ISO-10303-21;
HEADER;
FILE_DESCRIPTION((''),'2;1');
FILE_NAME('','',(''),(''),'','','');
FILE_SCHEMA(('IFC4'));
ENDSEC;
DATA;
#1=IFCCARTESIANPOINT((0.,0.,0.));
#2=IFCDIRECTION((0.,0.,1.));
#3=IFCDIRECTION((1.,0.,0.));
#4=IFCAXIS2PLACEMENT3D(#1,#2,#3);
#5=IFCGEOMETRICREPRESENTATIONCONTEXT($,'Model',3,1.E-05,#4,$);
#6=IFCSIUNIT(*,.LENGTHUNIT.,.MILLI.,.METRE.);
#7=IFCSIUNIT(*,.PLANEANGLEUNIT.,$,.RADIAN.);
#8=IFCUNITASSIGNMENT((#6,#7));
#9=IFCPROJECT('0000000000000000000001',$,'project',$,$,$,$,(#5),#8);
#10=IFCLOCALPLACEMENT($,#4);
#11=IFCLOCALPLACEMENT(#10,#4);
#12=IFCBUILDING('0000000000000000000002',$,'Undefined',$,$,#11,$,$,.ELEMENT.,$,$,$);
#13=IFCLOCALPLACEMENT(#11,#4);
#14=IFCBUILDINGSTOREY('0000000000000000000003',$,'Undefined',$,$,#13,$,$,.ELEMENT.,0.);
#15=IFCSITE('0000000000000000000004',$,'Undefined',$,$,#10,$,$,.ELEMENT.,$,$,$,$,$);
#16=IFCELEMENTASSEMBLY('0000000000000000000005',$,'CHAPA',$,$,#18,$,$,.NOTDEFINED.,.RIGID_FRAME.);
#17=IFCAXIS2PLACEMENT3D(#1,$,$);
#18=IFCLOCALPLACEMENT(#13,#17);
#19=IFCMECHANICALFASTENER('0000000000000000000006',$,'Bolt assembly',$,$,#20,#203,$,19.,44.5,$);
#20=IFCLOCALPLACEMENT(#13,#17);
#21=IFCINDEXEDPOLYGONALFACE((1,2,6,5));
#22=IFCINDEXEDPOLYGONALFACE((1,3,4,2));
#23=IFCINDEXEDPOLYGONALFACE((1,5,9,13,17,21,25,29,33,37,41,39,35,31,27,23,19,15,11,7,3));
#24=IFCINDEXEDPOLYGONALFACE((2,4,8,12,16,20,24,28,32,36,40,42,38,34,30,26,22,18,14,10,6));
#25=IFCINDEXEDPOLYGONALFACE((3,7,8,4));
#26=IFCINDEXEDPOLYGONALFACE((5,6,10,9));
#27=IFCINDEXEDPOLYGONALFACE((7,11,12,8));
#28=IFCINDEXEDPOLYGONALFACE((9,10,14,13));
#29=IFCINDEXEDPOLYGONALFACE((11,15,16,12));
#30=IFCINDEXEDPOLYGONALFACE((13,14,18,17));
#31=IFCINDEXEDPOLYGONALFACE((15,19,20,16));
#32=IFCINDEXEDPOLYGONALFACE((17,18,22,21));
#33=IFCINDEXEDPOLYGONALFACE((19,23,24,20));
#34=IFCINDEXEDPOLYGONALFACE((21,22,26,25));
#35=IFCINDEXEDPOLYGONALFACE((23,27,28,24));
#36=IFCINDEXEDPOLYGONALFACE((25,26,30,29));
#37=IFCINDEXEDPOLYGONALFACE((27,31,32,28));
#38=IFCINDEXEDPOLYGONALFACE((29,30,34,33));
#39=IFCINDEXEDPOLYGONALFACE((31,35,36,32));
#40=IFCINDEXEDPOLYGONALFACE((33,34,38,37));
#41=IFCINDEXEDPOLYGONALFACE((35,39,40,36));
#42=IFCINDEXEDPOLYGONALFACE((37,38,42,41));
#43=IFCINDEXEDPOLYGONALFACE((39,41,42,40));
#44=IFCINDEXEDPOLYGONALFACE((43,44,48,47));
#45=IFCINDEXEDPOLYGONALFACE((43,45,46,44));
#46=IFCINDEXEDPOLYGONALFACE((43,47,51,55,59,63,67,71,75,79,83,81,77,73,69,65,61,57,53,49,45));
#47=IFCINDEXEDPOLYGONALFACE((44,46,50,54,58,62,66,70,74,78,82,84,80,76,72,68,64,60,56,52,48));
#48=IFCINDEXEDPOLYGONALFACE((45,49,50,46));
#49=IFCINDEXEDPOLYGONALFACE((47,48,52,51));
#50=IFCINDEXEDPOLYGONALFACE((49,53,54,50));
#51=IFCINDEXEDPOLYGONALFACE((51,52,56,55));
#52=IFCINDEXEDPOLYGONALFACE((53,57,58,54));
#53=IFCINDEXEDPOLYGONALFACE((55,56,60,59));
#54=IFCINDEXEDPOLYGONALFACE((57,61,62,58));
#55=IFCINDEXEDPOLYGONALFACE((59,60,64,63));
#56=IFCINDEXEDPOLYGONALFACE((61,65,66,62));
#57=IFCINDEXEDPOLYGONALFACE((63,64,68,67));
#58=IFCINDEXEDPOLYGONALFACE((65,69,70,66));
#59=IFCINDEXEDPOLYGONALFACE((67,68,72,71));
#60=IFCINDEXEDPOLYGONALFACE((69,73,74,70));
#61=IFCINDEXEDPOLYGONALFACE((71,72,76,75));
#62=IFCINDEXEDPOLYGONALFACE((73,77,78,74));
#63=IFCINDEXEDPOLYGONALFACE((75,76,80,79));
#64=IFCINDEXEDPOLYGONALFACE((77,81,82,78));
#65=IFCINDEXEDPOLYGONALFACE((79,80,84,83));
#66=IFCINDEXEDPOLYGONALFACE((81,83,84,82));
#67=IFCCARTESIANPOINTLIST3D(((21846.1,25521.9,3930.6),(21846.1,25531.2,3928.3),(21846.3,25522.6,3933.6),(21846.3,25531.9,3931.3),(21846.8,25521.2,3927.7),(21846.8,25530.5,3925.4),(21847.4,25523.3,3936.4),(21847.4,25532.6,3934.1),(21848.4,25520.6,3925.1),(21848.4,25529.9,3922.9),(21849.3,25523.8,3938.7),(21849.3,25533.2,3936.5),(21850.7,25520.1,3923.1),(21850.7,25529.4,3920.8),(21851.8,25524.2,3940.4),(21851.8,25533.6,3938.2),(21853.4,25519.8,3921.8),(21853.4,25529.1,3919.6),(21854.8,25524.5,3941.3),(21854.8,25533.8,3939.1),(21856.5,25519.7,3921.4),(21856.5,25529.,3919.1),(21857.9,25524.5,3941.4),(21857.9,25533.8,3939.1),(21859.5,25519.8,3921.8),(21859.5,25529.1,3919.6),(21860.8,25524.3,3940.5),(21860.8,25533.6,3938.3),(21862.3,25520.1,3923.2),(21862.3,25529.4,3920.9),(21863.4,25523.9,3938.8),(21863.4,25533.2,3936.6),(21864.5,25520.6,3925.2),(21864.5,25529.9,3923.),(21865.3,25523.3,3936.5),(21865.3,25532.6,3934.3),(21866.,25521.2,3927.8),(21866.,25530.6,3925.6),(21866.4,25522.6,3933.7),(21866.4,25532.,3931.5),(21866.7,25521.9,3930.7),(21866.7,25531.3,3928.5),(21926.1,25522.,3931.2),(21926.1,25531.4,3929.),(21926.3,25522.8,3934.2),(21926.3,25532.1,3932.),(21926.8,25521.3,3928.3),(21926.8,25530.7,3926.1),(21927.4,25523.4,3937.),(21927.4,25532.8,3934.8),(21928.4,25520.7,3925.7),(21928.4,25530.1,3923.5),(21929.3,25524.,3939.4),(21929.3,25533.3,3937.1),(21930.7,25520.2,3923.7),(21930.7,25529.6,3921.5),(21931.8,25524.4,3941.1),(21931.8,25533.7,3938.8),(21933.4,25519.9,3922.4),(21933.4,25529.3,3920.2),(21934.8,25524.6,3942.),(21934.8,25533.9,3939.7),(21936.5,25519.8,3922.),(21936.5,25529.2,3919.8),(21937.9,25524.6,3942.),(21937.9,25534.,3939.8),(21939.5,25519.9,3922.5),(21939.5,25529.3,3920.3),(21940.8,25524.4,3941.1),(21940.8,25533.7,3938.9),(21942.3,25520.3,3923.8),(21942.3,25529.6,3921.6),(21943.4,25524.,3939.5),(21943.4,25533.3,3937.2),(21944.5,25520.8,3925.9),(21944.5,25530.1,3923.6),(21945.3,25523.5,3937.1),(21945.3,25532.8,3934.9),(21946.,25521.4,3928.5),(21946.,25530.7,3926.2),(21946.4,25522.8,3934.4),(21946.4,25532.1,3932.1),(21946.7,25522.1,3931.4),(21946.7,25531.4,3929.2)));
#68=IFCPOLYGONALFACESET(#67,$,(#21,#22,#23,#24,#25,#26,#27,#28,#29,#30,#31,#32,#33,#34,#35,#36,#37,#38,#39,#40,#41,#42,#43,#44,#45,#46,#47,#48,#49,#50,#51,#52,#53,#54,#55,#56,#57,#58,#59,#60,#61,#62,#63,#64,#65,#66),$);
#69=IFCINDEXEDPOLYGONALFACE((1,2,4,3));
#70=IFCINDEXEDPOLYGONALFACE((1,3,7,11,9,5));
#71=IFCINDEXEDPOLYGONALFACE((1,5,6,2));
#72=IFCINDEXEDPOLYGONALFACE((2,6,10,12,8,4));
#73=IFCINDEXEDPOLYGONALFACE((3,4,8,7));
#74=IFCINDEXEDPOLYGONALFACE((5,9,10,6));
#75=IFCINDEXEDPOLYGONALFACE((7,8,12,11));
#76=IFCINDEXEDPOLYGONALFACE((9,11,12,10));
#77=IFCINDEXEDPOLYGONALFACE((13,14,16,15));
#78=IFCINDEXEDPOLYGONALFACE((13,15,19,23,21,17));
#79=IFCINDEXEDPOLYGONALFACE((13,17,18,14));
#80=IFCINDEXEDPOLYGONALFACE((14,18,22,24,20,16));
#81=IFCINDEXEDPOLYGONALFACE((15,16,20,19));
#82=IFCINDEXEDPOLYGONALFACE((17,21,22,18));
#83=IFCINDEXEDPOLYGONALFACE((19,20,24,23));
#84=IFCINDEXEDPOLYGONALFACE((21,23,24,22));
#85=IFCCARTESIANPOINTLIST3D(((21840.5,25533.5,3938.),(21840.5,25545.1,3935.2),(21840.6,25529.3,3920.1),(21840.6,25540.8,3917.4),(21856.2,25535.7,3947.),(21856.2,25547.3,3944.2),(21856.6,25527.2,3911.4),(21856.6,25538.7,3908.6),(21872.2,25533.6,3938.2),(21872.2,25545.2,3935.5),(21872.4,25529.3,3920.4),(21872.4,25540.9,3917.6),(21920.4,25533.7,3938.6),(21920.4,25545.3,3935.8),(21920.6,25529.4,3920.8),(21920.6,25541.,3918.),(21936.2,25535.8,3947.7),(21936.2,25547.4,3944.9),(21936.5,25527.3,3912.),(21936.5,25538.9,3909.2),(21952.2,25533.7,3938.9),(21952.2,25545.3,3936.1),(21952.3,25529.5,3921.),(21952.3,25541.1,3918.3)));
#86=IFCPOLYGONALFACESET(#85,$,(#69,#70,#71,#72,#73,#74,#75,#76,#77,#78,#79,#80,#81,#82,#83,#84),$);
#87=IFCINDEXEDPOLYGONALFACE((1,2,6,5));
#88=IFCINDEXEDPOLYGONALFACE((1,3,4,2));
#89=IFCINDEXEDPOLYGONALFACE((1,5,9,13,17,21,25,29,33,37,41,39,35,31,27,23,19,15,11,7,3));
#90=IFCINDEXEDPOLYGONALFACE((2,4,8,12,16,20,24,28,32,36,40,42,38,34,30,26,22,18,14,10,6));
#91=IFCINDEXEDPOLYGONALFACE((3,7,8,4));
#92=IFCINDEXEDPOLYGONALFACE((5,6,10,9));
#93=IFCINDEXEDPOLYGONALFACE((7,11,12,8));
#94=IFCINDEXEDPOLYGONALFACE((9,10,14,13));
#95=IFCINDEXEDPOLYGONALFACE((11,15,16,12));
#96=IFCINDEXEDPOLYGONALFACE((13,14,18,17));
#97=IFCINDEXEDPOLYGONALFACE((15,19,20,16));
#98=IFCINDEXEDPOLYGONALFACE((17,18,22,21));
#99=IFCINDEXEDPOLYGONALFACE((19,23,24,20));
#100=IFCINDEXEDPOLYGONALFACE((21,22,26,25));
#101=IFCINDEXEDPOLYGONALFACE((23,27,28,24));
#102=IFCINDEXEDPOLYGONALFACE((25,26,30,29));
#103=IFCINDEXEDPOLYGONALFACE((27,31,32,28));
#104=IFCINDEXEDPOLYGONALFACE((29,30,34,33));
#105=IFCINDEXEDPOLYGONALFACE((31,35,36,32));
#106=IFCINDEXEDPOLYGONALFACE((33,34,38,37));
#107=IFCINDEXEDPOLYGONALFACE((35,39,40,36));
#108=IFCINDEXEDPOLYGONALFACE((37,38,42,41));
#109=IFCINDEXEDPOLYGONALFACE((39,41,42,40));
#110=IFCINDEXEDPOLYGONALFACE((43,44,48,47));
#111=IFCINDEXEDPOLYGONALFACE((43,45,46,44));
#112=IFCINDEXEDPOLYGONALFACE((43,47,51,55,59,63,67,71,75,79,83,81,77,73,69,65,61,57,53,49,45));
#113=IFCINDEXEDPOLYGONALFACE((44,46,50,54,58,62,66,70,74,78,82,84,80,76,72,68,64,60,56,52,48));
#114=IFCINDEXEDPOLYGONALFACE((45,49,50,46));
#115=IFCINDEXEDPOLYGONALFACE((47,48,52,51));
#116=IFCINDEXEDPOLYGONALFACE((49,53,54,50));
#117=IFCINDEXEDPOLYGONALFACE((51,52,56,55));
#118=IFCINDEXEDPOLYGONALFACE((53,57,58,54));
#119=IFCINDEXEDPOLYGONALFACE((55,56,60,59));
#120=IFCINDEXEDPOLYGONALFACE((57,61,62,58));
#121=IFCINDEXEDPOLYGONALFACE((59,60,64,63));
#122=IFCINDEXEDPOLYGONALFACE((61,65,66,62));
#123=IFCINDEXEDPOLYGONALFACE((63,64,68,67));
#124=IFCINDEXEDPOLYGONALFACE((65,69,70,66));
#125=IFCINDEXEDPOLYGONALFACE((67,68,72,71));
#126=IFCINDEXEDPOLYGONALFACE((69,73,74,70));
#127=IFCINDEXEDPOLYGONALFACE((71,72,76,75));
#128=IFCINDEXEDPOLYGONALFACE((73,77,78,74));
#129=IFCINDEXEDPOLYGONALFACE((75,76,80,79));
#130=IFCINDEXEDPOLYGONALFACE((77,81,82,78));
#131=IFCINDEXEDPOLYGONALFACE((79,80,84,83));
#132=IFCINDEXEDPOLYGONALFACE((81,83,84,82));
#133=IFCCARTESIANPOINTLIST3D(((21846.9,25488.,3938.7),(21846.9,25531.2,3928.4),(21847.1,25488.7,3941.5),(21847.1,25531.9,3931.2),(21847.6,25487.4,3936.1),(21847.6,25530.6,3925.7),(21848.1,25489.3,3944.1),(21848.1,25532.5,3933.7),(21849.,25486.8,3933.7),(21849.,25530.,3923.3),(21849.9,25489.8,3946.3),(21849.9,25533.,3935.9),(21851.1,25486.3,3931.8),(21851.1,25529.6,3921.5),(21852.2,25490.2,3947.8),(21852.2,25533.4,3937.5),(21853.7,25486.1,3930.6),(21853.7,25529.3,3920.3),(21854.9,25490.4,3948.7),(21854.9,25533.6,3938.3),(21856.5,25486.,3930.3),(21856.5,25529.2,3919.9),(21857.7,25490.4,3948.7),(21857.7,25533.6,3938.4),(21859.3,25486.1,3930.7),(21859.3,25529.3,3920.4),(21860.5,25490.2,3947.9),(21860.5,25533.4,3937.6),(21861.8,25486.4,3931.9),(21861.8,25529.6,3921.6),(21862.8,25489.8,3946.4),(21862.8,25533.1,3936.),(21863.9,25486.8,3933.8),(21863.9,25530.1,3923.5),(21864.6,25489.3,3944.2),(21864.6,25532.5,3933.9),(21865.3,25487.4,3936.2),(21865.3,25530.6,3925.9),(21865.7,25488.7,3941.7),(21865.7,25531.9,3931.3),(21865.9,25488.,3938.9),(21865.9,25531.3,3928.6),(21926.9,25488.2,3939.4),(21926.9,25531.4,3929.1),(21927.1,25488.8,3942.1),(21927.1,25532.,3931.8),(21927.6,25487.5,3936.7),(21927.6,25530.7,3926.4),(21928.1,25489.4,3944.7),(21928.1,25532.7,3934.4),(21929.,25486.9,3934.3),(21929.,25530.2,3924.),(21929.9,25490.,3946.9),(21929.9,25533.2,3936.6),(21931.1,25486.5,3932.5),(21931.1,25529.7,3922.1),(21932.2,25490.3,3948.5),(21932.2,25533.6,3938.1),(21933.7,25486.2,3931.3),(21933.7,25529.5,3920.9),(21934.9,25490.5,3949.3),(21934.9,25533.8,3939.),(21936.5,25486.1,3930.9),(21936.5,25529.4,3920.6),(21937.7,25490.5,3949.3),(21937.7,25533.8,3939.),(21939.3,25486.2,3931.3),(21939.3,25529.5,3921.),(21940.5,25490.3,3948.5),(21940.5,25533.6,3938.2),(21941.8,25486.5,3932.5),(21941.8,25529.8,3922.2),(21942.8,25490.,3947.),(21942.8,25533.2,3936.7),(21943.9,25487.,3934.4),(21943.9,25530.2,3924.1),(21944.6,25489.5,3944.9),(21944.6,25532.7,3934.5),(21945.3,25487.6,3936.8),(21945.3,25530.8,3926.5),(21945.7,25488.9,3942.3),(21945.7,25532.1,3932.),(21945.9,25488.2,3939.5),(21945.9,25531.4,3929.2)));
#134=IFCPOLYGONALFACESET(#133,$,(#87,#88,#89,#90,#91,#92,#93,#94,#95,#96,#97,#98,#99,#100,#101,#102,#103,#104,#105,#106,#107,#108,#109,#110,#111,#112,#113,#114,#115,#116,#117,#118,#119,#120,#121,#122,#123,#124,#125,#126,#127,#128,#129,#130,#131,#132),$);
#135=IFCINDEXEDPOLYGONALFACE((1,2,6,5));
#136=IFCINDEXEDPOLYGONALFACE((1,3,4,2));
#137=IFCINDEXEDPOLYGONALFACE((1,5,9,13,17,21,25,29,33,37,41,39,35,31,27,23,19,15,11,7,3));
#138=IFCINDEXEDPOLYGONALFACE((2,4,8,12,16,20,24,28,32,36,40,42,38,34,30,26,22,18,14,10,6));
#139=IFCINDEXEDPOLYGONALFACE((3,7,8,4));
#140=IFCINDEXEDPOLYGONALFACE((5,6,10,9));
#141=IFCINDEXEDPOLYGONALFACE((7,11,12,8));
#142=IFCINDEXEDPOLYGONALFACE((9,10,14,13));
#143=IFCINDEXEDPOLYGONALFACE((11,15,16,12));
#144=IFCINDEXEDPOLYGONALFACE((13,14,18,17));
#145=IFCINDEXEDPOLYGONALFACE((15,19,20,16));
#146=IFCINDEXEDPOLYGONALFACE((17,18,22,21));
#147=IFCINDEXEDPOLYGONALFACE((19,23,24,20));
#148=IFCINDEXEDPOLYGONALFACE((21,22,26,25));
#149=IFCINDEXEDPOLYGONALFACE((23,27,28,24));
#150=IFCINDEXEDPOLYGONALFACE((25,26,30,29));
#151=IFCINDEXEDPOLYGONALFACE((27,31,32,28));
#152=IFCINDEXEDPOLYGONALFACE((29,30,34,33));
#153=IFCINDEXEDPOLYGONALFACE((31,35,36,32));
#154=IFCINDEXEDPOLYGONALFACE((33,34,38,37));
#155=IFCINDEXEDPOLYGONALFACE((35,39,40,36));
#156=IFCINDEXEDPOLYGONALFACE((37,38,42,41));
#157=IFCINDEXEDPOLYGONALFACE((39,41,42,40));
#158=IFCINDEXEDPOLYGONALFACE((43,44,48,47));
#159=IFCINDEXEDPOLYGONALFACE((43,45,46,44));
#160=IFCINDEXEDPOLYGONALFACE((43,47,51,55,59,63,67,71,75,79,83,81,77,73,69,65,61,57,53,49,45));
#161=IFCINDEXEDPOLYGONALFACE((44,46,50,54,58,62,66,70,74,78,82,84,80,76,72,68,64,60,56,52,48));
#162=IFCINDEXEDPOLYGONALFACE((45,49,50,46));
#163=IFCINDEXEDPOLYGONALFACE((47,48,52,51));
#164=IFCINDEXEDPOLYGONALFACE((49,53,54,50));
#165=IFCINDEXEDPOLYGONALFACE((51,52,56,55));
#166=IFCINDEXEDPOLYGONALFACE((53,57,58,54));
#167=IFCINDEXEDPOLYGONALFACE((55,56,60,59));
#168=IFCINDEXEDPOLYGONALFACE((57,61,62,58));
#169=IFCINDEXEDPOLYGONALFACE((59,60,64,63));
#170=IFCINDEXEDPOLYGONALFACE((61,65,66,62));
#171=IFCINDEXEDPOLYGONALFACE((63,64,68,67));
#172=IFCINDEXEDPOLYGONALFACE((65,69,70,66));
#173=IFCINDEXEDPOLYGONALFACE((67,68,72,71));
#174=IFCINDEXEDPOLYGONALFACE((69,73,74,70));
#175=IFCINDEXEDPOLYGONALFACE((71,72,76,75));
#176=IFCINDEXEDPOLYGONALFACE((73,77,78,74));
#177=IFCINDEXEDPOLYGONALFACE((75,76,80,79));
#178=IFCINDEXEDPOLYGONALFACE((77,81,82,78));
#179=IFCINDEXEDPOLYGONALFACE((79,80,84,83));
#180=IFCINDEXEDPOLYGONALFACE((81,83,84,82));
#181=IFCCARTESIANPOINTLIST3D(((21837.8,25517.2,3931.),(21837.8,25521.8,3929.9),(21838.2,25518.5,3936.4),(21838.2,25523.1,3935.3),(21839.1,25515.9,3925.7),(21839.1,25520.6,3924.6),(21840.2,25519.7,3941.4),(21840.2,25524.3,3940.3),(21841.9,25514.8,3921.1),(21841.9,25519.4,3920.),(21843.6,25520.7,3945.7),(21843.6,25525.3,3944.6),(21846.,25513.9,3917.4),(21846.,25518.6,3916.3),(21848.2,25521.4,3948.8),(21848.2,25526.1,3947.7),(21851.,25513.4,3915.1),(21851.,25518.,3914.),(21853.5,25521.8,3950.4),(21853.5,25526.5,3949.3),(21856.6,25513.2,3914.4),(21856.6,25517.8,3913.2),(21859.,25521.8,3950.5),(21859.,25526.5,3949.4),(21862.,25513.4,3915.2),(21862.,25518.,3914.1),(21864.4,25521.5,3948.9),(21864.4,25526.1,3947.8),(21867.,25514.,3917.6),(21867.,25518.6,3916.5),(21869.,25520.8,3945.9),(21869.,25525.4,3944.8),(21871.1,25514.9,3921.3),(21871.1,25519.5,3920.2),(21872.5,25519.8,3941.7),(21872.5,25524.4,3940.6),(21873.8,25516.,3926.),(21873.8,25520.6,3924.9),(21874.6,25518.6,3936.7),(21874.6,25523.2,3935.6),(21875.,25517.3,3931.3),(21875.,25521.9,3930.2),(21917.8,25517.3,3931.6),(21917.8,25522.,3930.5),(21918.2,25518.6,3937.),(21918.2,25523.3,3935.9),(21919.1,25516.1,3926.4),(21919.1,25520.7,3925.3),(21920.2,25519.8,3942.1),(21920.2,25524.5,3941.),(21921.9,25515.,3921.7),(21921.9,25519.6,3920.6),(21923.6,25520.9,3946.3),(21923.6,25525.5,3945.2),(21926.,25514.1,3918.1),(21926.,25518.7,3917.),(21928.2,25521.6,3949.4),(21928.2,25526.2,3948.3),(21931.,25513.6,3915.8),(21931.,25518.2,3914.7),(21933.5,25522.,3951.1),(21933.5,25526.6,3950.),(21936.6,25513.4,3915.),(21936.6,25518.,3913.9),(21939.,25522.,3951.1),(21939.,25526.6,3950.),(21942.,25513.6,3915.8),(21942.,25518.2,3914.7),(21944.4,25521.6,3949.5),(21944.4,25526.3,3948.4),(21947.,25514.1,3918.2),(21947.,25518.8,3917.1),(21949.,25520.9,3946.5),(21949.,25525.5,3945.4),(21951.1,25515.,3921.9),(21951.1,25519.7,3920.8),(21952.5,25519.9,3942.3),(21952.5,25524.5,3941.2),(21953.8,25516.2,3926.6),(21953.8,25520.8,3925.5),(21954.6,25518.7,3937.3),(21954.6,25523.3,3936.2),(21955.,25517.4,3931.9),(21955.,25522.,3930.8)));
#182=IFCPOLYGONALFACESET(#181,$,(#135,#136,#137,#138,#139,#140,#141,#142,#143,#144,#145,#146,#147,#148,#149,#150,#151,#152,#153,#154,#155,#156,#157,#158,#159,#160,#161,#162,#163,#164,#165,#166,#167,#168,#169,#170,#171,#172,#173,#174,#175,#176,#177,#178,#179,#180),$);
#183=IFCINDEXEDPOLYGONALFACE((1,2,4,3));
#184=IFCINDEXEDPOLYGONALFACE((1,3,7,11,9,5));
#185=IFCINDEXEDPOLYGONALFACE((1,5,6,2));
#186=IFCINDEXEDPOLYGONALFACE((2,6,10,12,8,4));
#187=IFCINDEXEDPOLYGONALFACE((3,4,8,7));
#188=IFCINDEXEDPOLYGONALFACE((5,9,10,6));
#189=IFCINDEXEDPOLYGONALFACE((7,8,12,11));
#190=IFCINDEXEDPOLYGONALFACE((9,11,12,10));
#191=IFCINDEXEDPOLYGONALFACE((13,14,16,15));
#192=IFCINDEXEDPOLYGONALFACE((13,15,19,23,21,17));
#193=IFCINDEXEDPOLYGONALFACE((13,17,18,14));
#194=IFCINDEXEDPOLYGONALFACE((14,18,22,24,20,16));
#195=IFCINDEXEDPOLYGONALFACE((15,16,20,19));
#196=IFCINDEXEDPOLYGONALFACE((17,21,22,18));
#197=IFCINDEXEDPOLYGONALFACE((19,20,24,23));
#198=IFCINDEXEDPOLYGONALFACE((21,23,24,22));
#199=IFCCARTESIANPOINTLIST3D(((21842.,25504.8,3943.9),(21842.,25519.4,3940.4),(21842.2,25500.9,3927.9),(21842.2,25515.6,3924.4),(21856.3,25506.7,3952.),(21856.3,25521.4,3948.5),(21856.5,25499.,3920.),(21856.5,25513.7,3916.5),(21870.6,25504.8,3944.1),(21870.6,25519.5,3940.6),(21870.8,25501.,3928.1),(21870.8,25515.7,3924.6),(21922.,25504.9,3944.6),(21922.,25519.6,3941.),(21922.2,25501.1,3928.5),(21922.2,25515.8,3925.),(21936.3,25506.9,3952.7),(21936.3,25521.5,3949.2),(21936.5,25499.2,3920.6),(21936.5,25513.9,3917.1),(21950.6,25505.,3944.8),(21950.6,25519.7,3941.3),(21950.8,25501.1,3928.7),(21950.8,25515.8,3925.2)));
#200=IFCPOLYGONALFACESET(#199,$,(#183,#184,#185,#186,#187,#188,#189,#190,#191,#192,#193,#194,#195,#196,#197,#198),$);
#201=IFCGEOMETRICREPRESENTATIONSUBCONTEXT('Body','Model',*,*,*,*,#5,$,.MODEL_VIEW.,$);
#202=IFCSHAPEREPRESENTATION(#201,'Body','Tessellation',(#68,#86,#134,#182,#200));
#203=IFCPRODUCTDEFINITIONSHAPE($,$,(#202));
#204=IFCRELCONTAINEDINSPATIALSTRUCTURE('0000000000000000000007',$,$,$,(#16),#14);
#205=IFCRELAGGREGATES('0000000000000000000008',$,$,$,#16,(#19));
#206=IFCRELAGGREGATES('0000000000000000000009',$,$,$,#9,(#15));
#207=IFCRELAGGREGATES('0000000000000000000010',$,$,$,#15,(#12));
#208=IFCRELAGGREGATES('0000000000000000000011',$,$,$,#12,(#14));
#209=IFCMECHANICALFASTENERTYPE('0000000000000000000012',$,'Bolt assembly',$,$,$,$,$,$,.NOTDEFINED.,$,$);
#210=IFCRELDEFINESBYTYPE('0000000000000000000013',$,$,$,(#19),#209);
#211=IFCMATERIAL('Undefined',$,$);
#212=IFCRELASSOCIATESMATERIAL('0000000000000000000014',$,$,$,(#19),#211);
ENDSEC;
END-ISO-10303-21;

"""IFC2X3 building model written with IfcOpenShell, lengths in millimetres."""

from ifc_helpers import new_model, si_unit, frame, origin_with_axes, origin_2d_with_axis, place, context, subcontext, project, spatial, polyline, circle, outline, extrude, source, transform, mapped, material, type_object, element, aggregate, save


model = new_model("IFC2X3")

# Units and contexts
model_context = context("Model", 3, precision=1e-05, world=origin_with_axes())
body_context = subcontext(model_context, "Body", "Model", "MODEL_VIEW")
ifc_project = project(units=[si_unit("LENGTHUNIT", "METRE", prefix="MILLI"), si_unit("PLANEANGLEUNIT", "RADIAN")], contexts=[model_context])

# Site, building, storey
site_placement = place(None, origin_with_axes())
site = spatial("IfcSite", under=ifc_project, at=site_placement, Name="Undefined", CompositionType="ELEMENT")
building_placement = place(site_placement, origin_with_axes())
building = spatial("IfcBuilding", under=site, at=building_placement, Name="Undefined", CompositionType="ELEMENT")
storey_placement = place(building_placement, origin_with_axes())
storey = spatial("IfcBuildingStorey", under=building, at=storey_placement, Name="Undefined", CompositionType="ELEMENT", Elevation=0.0)

# Element assembly
assembly_1_placement = place(storey_placement, origin_with_axes())
assembly_1 = element("IfcElementAssembly", 1, at=assembly_1_placement, inside=storey, Name="CHAPA", AssemblyPlace="NOTDEFINED", PredefinedType="RIGID_FRAME")

# Shared definitions
ifc_material_1 = material(Name="Undefined")
mechanical_fastener_type = type_object("IfcMechanicalFastenerType", Name="Bolt assembly")

# Mechanical fastener
shared_shape_1 = source(origin_with_axes(), body_context, "Body", "SweptSolid", [
    extrude(circle(Radius=10.3, at=origin_2d_with_axis()), frame((0.0, 0.0, 0.0), z_axis=(0.0, 1.0, 0.0), x_axis=(1.0, 0.0, 0.0)), (0.0, 0.0, 1.0), 9.6),
    extrude(outline(polyline([(18.3, 0.0), (9.2, 15.9), (-9.2, 15.9), (-18.3, 0.0), (-9.2, -15.9), (9.2, -15.9), (18.3, 0.0)])), frame((0.0, -11.9, 0.0), z_axis=(0.0, 1.0, 0.0), x_axis=(1.0, 0.0, 0.0)), (0.0, 0.0, 1.0), 11.9),
    extrude(circle(Radius=9.5, at=origin_2d_with_axis()), frame((0.0, 0.0, 0.0), z_axis=(0.0, 1.0, 0.0), x_axis=(1.0, 0.0, 0.0)), (0.0, 0.0, 1.0), 44.5),
    extrude(circle(Radius=18.7, at=origin_2d_with_axis()), frame((0.0, 9.5, 0.0), z_axis=(0.0, 1.0, 0.0), x_axis=(1.0, 0.0, 0.0)), (0.0, 0.0, 1.0), 4.8),
    extrude(outline(polyline([(16.5, 0.0), (8.2, 14.3), (-8.2, 14.3), (-16.5, 0.0), (-8.2, -14.3), (8.2, -14.3), (16.5, 0.0)])), frame((0.0, 14.3, 0.0), z_axis=(0.0, 1.0, 0.0), x_axis=(1.0, 0.0, 0.0)), (0.0, 0.0, 1.0), 15.1),
])
mechanical_fastener_1_placement = place(assembly_1_placement, frame((21896.4, 25531.5, 3929.5), z_axis=(-0.999966, -0.001919, -0.008026), x_axis=(0.008253, -0.23249, -0.972564)))
mechanical_fastener_1 = element("IfcMechanicalFastener", 2, at=mechanical_fastener_1_placement, type_object=mechanical_fastener_type, material=ifc_material_1, Name="Bolt assembly", NominalDiameter=19.0, NominalLength=44.5, context=body_context, shape_type="MappedRepresentation", body=[
    mapped(shared_shape_1, transform((0.0, 0.0, 40.0))),
    mapped(shared_shape_1, transform((0.0, 0.0, -40.0))),
])
aggregate(assembly_1, [mechanical_fastener_1])

save(model, "model.ifc")
